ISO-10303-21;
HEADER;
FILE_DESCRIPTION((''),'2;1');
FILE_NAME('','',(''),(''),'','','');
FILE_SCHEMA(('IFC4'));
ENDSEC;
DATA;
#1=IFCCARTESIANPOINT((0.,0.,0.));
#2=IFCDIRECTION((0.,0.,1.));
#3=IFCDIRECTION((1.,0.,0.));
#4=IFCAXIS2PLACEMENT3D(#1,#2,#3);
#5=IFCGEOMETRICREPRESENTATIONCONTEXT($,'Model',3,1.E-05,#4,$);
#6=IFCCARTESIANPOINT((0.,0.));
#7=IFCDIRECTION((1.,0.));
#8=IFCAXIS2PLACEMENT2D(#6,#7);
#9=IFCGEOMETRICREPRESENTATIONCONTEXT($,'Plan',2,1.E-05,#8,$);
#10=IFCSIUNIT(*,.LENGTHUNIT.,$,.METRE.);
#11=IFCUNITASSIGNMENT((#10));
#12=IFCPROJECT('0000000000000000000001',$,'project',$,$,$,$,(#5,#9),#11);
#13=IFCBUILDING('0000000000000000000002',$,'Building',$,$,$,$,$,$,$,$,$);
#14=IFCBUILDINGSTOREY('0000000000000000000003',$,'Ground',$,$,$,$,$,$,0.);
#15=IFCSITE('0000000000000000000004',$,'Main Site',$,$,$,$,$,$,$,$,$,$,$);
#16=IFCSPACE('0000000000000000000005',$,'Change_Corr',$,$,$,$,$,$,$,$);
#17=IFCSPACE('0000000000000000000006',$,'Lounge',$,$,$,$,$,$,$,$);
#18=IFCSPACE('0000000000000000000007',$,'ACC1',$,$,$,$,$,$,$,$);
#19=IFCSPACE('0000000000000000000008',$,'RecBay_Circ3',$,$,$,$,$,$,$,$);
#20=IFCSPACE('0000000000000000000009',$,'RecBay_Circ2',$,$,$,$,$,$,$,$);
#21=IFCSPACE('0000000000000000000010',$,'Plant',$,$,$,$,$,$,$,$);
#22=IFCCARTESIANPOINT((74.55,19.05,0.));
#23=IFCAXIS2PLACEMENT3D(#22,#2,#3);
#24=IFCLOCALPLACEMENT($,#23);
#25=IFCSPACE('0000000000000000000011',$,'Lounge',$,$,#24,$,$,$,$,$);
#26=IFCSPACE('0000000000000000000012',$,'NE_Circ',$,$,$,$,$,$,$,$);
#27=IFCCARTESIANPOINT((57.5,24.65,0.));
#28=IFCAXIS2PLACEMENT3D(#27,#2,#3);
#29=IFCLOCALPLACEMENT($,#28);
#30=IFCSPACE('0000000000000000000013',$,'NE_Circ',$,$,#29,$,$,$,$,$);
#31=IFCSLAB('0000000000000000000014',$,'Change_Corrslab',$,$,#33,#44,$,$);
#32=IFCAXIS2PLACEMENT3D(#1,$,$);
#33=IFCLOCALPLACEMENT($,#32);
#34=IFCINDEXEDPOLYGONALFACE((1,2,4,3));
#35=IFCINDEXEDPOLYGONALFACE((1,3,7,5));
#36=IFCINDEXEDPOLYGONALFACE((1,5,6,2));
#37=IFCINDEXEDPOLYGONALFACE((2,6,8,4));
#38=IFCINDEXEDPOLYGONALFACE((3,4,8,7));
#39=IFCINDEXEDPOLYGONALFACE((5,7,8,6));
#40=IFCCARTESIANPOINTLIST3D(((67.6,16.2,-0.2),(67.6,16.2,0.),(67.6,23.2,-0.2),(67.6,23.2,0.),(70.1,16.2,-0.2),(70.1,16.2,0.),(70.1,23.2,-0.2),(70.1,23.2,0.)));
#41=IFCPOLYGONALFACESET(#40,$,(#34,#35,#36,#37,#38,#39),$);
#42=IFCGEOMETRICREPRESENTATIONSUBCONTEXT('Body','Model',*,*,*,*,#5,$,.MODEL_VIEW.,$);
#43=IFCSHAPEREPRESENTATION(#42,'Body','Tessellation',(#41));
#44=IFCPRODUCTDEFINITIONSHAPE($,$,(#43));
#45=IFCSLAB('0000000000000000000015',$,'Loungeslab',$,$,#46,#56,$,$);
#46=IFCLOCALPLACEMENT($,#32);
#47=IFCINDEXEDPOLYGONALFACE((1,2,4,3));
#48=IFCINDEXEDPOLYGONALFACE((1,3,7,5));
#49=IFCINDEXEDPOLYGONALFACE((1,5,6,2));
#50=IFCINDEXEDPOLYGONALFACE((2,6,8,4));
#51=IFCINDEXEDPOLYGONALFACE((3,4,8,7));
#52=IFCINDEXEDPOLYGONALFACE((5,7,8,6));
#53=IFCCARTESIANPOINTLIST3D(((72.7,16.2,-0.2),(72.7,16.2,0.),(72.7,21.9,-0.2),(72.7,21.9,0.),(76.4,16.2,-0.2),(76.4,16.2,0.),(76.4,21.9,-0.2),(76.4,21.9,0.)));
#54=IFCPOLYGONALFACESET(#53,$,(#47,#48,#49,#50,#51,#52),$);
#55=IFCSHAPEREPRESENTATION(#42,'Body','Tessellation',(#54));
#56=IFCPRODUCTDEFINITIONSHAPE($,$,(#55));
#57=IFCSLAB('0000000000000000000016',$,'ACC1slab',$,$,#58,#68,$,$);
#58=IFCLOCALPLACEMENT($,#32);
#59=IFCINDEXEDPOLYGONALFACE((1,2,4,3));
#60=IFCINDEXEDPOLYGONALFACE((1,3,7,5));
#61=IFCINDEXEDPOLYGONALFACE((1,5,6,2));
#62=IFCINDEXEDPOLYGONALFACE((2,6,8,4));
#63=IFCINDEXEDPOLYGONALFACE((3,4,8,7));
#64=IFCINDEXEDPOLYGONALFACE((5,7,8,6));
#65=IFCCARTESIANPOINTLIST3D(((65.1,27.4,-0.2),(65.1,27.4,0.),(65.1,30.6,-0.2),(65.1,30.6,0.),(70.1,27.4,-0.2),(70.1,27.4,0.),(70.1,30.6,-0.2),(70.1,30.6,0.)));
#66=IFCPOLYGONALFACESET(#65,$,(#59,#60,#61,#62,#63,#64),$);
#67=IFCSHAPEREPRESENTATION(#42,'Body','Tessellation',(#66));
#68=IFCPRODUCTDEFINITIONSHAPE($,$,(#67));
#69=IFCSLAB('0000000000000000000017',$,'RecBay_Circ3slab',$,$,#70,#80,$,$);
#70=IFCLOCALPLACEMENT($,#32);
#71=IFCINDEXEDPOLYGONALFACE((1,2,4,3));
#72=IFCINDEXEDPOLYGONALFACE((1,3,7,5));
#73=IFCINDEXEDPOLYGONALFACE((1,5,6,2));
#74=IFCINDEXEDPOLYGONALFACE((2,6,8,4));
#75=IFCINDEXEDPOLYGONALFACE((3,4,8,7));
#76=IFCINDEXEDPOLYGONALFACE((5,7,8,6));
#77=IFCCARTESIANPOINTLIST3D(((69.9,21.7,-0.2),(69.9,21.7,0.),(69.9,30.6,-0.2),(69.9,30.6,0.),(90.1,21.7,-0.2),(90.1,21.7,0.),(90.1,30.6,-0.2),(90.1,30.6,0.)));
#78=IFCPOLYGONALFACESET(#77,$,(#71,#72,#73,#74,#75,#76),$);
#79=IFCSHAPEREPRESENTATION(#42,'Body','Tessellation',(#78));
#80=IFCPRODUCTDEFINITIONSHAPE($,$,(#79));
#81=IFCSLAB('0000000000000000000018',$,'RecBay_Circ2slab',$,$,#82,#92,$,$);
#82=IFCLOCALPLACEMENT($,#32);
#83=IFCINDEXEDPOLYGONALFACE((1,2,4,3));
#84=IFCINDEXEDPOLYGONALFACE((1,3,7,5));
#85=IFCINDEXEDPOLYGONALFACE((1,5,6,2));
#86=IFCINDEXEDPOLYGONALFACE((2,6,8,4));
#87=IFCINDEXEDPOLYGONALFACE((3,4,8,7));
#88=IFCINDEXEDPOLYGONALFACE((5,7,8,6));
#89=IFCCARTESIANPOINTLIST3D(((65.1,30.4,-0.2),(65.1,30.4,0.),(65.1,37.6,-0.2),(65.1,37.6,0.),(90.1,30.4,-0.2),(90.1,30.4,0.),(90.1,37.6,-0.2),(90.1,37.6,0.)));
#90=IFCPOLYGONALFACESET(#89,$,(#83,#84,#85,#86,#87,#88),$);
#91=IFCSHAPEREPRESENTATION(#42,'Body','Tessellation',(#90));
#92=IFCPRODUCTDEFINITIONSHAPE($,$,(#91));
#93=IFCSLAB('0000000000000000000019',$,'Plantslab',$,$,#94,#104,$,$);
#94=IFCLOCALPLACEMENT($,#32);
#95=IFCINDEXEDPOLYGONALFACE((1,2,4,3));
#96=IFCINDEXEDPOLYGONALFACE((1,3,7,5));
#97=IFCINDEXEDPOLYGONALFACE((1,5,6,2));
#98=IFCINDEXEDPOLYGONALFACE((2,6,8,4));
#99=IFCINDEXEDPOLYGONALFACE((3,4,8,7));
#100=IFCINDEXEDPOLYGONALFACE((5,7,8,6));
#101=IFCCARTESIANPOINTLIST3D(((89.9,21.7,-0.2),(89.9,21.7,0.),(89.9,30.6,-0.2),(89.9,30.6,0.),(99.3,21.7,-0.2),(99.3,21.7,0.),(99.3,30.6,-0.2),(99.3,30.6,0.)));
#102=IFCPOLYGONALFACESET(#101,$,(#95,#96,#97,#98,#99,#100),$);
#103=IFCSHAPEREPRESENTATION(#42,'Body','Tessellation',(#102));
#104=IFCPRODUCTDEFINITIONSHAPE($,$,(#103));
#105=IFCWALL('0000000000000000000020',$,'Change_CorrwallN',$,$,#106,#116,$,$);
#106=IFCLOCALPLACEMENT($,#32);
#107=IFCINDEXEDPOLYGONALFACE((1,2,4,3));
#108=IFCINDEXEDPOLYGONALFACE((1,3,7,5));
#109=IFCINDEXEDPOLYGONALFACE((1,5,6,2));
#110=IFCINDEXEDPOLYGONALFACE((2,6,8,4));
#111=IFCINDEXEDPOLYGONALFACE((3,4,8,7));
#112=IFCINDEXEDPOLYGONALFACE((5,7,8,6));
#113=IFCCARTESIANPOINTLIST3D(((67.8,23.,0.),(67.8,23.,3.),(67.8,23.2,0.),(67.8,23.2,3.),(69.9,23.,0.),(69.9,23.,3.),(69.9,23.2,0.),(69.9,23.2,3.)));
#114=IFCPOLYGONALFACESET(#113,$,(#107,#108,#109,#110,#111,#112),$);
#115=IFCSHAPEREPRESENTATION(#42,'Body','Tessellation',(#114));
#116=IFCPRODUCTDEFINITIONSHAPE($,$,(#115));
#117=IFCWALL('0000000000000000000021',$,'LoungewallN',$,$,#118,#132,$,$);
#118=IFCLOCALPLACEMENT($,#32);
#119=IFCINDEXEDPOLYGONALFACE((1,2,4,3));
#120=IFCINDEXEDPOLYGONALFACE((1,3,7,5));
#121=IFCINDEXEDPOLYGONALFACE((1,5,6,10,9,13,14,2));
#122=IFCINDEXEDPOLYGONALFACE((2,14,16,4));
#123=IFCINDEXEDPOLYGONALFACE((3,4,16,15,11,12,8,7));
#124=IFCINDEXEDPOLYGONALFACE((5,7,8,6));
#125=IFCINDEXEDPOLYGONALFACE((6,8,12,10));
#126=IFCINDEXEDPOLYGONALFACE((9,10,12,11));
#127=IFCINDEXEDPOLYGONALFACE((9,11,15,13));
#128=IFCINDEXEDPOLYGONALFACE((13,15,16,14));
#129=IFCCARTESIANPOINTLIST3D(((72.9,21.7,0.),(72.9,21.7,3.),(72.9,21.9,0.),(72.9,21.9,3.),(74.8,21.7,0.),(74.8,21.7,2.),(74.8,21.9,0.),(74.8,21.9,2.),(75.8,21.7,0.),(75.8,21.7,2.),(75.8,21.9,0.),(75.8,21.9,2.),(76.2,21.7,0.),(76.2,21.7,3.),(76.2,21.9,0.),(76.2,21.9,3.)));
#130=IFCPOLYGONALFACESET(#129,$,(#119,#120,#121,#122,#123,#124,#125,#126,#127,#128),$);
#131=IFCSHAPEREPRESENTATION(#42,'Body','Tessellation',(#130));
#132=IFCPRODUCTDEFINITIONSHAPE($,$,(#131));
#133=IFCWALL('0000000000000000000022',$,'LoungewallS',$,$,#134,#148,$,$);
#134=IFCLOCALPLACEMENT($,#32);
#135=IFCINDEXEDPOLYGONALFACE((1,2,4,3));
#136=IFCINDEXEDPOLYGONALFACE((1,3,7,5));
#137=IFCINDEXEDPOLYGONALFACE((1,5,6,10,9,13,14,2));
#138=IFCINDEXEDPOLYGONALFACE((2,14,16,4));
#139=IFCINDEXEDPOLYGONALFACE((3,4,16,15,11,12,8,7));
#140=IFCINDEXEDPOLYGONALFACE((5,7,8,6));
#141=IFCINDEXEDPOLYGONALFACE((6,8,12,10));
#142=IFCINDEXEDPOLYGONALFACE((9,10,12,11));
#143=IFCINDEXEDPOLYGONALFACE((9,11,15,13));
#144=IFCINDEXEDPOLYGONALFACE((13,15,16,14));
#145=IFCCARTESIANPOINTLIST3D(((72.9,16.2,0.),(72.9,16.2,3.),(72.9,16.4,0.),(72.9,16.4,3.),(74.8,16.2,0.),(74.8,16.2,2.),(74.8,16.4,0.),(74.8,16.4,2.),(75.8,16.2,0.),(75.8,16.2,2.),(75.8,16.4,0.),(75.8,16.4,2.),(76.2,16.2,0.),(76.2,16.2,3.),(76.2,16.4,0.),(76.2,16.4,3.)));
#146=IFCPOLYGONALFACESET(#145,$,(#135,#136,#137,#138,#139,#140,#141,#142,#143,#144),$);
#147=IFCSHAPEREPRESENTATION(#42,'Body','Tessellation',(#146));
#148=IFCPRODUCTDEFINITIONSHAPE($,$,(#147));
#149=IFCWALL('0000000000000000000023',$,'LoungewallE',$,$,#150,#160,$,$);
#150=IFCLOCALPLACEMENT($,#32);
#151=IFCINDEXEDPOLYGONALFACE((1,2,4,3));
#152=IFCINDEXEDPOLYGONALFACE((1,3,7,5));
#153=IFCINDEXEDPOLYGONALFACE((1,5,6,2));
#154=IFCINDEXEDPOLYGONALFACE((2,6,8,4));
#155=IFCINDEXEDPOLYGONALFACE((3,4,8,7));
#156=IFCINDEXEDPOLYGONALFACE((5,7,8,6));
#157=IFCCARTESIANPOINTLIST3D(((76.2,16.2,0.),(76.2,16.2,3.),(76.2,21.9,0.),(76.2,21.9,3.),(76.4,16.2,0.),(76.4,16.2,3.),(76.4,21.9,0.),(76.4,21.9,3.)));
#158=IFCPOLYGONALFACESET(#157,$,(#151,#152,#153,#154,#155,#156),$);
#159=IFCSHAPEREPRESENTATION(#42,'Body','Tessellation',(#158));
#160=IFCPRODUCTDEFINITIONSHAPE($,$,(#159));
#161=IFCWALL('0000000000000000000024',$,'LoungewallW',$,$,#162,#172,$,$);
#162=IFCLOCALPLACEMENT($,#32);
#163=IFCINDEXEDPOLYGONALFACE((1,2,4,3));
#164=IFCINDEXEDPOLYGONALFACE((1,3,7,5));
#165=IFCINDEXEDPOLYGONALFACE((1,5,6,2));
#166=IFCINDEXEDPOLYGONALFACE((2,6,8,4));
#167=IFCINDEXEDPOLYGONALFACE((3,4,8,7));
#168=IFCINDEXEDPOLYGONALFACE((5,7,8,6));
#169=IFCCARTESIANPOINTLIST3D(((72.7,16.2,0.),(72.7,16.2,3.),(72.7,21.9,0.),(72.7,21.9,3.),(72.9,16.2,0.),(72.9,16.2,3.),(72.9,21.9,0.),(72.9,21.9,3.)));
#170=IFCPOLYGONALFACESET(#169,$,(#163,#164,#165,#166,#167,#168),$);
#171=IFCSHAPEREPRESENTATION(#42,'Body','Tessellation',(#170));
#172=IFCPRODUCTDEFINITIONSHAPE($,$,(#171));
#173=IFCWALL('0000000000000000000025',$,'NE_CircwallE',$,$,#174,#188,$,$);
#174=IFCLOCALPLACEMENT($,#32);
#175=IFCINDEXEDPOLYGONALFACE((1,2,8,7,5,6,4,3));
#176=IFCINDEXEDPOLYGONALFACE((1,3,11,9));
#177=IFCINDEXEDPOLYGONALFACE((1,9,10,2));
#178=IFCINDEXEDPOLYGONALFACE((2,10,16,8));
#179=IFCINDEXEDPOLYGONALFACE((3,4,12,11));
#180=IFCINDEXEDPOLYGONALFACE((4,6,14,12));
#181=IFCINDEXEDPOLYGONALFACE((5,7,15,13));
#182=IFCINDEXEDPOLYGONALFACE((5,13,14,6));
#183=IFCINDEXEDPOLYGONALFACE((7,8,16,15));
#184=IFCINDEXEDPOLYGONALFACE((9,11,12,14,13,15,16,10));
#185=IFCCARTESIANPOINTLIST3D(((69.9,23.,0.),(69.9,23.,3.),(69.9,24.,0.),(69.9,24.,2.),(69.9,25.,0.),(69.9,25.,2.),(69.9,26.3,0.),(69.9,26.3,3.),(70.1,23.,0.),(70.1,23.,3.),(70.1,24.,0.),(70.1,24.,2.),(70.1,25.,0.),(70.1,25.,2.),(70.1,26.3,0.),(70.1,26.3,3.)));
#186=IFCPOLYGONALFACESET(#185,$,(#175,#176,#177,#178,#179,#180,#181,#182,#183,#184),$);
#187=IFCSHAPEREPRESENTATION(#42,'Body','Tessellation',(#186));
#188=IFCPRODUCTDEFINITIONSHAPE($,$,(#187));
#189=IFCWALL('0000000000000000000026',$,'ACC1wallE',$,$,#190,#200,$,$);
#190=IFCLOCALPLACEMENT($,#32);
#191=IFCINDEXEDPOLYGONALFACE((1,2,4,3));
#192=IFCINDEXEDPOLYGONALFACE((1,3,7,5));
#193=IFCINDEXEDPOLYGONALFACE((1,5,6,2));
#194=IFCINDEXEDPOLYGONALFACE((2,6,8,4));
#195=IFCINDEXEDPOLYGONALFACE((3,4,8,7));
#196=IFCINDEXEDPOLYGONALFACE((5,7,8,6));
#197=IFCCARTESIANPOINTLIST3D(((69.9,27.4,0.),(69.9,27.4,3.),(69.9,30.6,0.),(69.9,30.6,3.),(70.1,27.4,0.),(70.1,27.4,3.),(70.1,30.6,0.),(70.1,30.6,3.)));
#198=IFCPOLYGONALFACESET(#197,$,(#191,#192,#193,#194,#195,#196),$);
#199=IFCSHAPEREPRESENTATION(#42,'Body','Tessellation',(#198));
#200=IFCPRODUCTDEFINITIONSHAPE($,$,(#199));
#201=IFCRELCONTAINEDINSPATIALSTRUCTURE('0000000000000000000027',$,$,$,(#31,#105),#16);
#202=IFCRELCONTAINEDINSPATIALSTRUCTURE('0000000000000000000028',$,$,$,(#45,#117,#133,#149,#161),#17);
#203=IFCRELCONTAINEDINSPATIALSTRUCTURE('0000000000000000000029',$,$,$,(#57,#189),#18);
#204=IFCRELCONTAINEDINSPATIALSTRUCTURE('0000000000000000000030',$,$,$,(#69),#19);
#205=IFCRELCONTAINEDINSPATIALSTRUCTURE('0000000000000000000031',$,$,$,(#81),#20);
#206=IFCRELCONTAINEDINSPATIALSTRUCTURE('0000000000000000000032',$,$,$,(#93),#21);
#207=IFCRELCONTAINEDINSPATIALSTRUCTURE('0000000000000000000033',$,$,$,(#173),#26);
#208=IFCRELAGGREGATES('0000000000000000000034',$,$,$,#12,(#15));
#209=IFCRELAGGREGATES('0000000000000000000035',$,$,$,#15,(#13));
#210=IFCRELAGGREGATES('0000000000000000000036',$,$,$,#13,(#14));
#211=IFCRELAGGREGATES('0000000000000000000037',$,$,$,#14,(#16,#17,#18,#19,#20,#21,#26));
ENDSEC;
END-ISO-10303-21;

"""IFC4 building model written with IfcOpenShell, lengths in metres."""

from ifc_helpers import new_model, si_unit, frame, origin_with_axes, origin_2d_with_axis, place, context, subcontext, project, spatial, indexed_curve, rectangle, outline, extrude, element, save


model = new_model("IFC4")

# Units and contexts
model_context = context("Model", 3, precision=1e-05, world=origin_with_axes())
plan_context = context("Plan", 2, precision=1e-05, world=origin_2d_with_axis())
body_context = subcontext(model_context, "Body", "Model", "MODEL_VIEW")
ifc_project = project(units=[si_unit("LENGTHUNIT", "METRE")], contexts=[model_context, plan_context])

# Site, building, storey, space
site = spatial("IfcSite", under=ifc_project, Name="Main Site")
building = spatial("IfcBuilding", under=site, Name="Building")
storey = spatial("IfcBuildingStorey", under=building, Name="Ground", Elevation=0.0)
space_1 = spatial("IfcSpace", under=storey, Name="Change_Corr")

# Slab
slab_1_placement = place(None, frame((68.85, 19.7, -0.2), z_axis=(0.0, 0.0, 1.0), x_axis=(1.0, 0.0, 0.0)))
element("IfcSlab", 1, at=slab_1_placement, inside=space_1, Name="Change_Corrslab", context=body_context, shape_type="SweptSolid", body=[
    extrude(rectangle(XDim=2.5, YDim=7.0), origin_with_axes(), (0.0, 0.0, 1.0), 0.2),
])

# Shared definitions
space_2 = spatial("IfcSpace", under=storey, Name="Lounge")

# Slab
slab_2_placement = place(None, frame((74.55, 19.05, -0.2), z_axis=(0.0, 0.0, 1.0), x_axis=(1.0, 0.0, 0.0)))
element("IfcSlab", 2, at=slab_2_placement, inside=space_2, Name="Loungeslab", context=body_context, shape_type="SweptSolid", body=[
    extrude(rectangle(XDim=3.7, YDim=5.7), origin_with_axes(), (0.0, 0.0, 1.0), 0.2),
])

# Shared definitions
space_3 = spatial("IfcSpace", under=storey, Name="ACC1")

# Slab
slab_3_placement = place(None, frame((67.6, 29.0, -0.2), z_axis=(0.0, 0.0, 1.0), x_axis=(1.0, 0.0, 0.0)))
element("IfcSlab", 3, at=slab_3_placement, inside=space_3, Name="ACC1slab", context=body_context, shape_type="SweptSolid", body=[
    extrude(rectangle(XDim=5.0, YDim=3.2), origin_with_axes(), (0.0, 0.0, 1.0), 0.2),
])

# Shared definitions
space_4 = spatial("IfcSpace", under=storey, Name="RecBay_Circ3")

# Slab
slab_4_placement = place(None, frame((80.0, 26.15, -0.2), z_axis=(0.0, 0.0, 1.0), x_axis=(1.0, 0.0, 0.0)))
element("IfcSlab", 4, at=slab_4_placement, inside=space_4, Name="RecBay_Circ3slab", context=body_context, shape_type="SweptSolid", body=[
    extrude(rectangle(XDim=20.2, YDim=8.9), origin_with_axes(), (0.0, 0.0, 1.0), 0.2),
])

# Shared definitions
space_5 = spatial("IfcSpace", under=storey, Name="RecBay_Circ2")

# Slab
slab_5_placement = place(None, frame((77.6, 34.0, -0.2), z_axis=(0.0, 0.0, 1.0), x_axis=(1.0, 0.0, 0.0)))
element("IfcSlab", 5, at=slab_5_placement, inside=space_5, Name="RecBay_Circ2slab", context=body_context, shape_type="SweptSolid", body=[
    extrude(rectangle(XDim=25.0, YDim=7.2), origin_with_axes(), (0.0, 0.0, 1.0), 0.2),
])

# Shared definitions
space_6 = spatial("IfcSpace", under=storey, Name="Plant")

# Slab
slab_6_placement = place(None, frame((94.6, 26.15, -0.2), z_axis=(0.0, 0.0, 1.0), x_axis=(1.0, 0.0, 0.0)))
element("IfcSlab", 6, at=slab_6_placement, inside=space_6, Name="Plantslab", context=body_context, shape_type="SweptSolid", body=[
    extrude(rectangle(XDim=9.4, YDim=8.9), origin_with_axes(), (0.0, 0.0, 1.0), 0.2),
])

# Walls
wall_1_placement = place(None, frame((67.8, 23.0, 0.0), z_axis=(0.0, 0.0, 1.0), x_axis=(1.0, 0.0, 0.0)))
element("IfcWall", 7, at=wall_1_placement, inside=space_1, Name="Change_CorrwallN", context=body_context, shape_type="SweptSolid", body=[
    extrude(outline(indexed_curve([(0.0, 0.0), (0.0, 0.2), (2.1, 0.2), (2.1, 0.0), (0.0, 0.0)], self_intersect=False)), origin_with_axes(), (0.0, 0.0, 1.0), 3.0),
])
wall_2_placement = place(None, frame((72.9, 21.7, 0.0), z_axis=(0.0, 0.0, 1.0), x_axis=(1.0, 0.0, 0.0)))
wall_2 = element("IfcWall", 8, at=wall_2_placement, inside=space_2, Name="LoungewallN", context=body_context, shape_type="SweptSolid", body=[
    extrude(outline(indexed_curve([(0.0, 0.0), (0.0, 0.2), (3.3, 0.2), (3.3, 0.0), (0.0, 0.0)], self_intersect=False)), origin_with_axes(), (0.0, 0.0, 1.0), 3.0),
])

# Shared definitions
space_7_placement = place(None, frame((74.55, 19.05, 0.0), z_axis=(0.0, 0.0, 1.0), x_axis=(1.0, 0.0, 0.0)))
space_7 = spatial("IfcSpace", at=space_7_placement, Name="Lounge")

# Opening
opening_1_placement = place(wall_2_placement, frame((1.9, 0.0, 0.0), z_axis=(0.0, 0.0, 1.0), x_axis=(1.0, 0.0, 0.0)))
element("IfcOpeningElement", 9, at=opening_1_placement, inside=space_7, cuts=wall_2, context=body_context, shape_type="SweptSolid", body=[
    extrude(outline(indexed_curve([(0.0, 0.0), (0.0, 0.4), (1.0, 0.4), (1.0, 0.0), (0.0, 0.0)], self_intersect=False)), origin_with_axes(), (0.0, 0.0, 1.0), 2.0),
])

# Wall, opening
wall_3_placement = place(None, frame((72.9, 16.2, 0.0), z_axis=(0.0, 0.0, 1.0), x_axis=(1.0, 0.0, 0.0)))
wall_3 = element("IfcWall", 10, at=wall_3_placement, inside=space_2, Name="LoungewallS", context=body_context, shape_type="SweptSolid", body=[
    extrude(outline(indexed_curve([(0.0, 0.0), (0.0, 0.2), (3.3, 0.2), (3.3, 0.0), (0.0, 0.0)], self_intersect=False)), origin_with_axes(), (0.0, 0.0, 1.0), 3.0),
])
opening_2_placement = place(wall_3_placement, frame((1.9, 0.0, 0.0), z_axis=(0.0, 0.0, 1.0), x_axis=(1.0, 0.0, 0.0)))
element("IfcOpeningElement", 11, at=opening_2_placement, inside=space_7, cuts=wall_3, context=body_context, shape_type="SweptSolid", body=[
    extrude(outline(indexed_curve([(0.0, 0.0), (0.0, 0.4), (1.0, 0.4), (1.0, 0.0), (0.0, 0.0)], self_intersect=False)), origin_with_axes(), (0.0, 0.0, 1.0), 2.0),
])

# Walls
for number, where, z_axis, x_axis, name in (
    (12, (76.4, 16.2, 0.0), (0.0, 0.0, 1.0), (0.0, 1.0, 0.0), "LoungewallE"),
    (13, (72.9, 16.2, 0.0), (0.0, 0.0, 1.0), (0.0, 1.0, 0.0), "LoungewallW"),
):
    element("IfcWall", number, at=place(None, frame(where, z_axis=z_axis, x_axis=x_axis)), inside=space_2, Name=name, context=body_context, shape_type="SweptSolid", body=[
        extrude(outline(indexed_curve([(0.0, 0.0), (0.0, 0.2), (5.7, 0.2), (5.7, 0.0), (0.0, 0.0)], self_intersect=False)), origin_with_axes(), (0.0, 0.0, 1.0), 3.0),
    ])

# Shared definitions
space_8 = spatial("IfcSpace", under=storey, Name="NE_Circ")

# Wall
wall_4_placement = place(None, frame((70.1, 23.0, 0.0), z_axis=(0.0, 0.0, 1.0), x_axis=(0.0, 1.0, 0.0)))
wall_4 = element("IfcWall", 14, at=wall_4_placement, inside=space_8, Name="NE_CircwallE", context=body_context, shape_type="SweptSolid", body=[
    extrude(outline(indexed_curve([(0.0, 0.0), (0.0, 0.2), (3.3, 0.2), (3.3, 0.0), (0.0, 0.0)], self_intersect=False)), origin_with_axes(), (0.0, 0.0, 1.0), 3.0),
])

# Shared definitions
space_9_placement = place(None, frame((57.5, 24.65, 0.0), z_axis=(0.0, 0.0, 1.0), x_axis=(1.0, 0.0, 0.0)))
space_9 = spatial("IfcSpace", at=space_9_placement, Name="NE_Circ")

# Opening
opening_3_placement = place(wall_4_placement, frame((1.0, 0.0, 0.0), z_axis=(0.0, 0.0, 1.0), x_axis=(1.0, 0.0, 0.0)))
element("IfcOpeningElement", 15, at=opening_3_placement, inside=space_9, cuts=wall_4, context=body_context, shape_type="SweptSolid", body=[
    extrude(outline(indexed_curve([(0.0, 0.0), (0.0, 0.4), (1.0, 0.4), (1.0, 0.0), (0.0, 0.0)], self_intersect=False)), origin_with_axes(), (0.0, 0.0, 1.0), 2.0),
])

# Wall
wall_5_placement = place(None, frame((70.1, 27.4, 0.0), z_axis=(0.0, 0.0, 1.0), x_axis=(0.0, 1.0, 0.0)))
element("IfcWall", 16, at=wall_5_placement, inside=space_3, Name="ACC1wallE", context=body_context, shape_type="SweptSolid", body=[
    extrude(outline(indexed_curve([(0.0, 0.0), (0.0, 0.2), (3.2, 0.2), (3.2, 0.0), (0.0, 0.0)], self_intersect=False)), origin_with_axes(), (0.0, 0.0, 1.0), 3.0),
])

save(model, "model.ifc")
